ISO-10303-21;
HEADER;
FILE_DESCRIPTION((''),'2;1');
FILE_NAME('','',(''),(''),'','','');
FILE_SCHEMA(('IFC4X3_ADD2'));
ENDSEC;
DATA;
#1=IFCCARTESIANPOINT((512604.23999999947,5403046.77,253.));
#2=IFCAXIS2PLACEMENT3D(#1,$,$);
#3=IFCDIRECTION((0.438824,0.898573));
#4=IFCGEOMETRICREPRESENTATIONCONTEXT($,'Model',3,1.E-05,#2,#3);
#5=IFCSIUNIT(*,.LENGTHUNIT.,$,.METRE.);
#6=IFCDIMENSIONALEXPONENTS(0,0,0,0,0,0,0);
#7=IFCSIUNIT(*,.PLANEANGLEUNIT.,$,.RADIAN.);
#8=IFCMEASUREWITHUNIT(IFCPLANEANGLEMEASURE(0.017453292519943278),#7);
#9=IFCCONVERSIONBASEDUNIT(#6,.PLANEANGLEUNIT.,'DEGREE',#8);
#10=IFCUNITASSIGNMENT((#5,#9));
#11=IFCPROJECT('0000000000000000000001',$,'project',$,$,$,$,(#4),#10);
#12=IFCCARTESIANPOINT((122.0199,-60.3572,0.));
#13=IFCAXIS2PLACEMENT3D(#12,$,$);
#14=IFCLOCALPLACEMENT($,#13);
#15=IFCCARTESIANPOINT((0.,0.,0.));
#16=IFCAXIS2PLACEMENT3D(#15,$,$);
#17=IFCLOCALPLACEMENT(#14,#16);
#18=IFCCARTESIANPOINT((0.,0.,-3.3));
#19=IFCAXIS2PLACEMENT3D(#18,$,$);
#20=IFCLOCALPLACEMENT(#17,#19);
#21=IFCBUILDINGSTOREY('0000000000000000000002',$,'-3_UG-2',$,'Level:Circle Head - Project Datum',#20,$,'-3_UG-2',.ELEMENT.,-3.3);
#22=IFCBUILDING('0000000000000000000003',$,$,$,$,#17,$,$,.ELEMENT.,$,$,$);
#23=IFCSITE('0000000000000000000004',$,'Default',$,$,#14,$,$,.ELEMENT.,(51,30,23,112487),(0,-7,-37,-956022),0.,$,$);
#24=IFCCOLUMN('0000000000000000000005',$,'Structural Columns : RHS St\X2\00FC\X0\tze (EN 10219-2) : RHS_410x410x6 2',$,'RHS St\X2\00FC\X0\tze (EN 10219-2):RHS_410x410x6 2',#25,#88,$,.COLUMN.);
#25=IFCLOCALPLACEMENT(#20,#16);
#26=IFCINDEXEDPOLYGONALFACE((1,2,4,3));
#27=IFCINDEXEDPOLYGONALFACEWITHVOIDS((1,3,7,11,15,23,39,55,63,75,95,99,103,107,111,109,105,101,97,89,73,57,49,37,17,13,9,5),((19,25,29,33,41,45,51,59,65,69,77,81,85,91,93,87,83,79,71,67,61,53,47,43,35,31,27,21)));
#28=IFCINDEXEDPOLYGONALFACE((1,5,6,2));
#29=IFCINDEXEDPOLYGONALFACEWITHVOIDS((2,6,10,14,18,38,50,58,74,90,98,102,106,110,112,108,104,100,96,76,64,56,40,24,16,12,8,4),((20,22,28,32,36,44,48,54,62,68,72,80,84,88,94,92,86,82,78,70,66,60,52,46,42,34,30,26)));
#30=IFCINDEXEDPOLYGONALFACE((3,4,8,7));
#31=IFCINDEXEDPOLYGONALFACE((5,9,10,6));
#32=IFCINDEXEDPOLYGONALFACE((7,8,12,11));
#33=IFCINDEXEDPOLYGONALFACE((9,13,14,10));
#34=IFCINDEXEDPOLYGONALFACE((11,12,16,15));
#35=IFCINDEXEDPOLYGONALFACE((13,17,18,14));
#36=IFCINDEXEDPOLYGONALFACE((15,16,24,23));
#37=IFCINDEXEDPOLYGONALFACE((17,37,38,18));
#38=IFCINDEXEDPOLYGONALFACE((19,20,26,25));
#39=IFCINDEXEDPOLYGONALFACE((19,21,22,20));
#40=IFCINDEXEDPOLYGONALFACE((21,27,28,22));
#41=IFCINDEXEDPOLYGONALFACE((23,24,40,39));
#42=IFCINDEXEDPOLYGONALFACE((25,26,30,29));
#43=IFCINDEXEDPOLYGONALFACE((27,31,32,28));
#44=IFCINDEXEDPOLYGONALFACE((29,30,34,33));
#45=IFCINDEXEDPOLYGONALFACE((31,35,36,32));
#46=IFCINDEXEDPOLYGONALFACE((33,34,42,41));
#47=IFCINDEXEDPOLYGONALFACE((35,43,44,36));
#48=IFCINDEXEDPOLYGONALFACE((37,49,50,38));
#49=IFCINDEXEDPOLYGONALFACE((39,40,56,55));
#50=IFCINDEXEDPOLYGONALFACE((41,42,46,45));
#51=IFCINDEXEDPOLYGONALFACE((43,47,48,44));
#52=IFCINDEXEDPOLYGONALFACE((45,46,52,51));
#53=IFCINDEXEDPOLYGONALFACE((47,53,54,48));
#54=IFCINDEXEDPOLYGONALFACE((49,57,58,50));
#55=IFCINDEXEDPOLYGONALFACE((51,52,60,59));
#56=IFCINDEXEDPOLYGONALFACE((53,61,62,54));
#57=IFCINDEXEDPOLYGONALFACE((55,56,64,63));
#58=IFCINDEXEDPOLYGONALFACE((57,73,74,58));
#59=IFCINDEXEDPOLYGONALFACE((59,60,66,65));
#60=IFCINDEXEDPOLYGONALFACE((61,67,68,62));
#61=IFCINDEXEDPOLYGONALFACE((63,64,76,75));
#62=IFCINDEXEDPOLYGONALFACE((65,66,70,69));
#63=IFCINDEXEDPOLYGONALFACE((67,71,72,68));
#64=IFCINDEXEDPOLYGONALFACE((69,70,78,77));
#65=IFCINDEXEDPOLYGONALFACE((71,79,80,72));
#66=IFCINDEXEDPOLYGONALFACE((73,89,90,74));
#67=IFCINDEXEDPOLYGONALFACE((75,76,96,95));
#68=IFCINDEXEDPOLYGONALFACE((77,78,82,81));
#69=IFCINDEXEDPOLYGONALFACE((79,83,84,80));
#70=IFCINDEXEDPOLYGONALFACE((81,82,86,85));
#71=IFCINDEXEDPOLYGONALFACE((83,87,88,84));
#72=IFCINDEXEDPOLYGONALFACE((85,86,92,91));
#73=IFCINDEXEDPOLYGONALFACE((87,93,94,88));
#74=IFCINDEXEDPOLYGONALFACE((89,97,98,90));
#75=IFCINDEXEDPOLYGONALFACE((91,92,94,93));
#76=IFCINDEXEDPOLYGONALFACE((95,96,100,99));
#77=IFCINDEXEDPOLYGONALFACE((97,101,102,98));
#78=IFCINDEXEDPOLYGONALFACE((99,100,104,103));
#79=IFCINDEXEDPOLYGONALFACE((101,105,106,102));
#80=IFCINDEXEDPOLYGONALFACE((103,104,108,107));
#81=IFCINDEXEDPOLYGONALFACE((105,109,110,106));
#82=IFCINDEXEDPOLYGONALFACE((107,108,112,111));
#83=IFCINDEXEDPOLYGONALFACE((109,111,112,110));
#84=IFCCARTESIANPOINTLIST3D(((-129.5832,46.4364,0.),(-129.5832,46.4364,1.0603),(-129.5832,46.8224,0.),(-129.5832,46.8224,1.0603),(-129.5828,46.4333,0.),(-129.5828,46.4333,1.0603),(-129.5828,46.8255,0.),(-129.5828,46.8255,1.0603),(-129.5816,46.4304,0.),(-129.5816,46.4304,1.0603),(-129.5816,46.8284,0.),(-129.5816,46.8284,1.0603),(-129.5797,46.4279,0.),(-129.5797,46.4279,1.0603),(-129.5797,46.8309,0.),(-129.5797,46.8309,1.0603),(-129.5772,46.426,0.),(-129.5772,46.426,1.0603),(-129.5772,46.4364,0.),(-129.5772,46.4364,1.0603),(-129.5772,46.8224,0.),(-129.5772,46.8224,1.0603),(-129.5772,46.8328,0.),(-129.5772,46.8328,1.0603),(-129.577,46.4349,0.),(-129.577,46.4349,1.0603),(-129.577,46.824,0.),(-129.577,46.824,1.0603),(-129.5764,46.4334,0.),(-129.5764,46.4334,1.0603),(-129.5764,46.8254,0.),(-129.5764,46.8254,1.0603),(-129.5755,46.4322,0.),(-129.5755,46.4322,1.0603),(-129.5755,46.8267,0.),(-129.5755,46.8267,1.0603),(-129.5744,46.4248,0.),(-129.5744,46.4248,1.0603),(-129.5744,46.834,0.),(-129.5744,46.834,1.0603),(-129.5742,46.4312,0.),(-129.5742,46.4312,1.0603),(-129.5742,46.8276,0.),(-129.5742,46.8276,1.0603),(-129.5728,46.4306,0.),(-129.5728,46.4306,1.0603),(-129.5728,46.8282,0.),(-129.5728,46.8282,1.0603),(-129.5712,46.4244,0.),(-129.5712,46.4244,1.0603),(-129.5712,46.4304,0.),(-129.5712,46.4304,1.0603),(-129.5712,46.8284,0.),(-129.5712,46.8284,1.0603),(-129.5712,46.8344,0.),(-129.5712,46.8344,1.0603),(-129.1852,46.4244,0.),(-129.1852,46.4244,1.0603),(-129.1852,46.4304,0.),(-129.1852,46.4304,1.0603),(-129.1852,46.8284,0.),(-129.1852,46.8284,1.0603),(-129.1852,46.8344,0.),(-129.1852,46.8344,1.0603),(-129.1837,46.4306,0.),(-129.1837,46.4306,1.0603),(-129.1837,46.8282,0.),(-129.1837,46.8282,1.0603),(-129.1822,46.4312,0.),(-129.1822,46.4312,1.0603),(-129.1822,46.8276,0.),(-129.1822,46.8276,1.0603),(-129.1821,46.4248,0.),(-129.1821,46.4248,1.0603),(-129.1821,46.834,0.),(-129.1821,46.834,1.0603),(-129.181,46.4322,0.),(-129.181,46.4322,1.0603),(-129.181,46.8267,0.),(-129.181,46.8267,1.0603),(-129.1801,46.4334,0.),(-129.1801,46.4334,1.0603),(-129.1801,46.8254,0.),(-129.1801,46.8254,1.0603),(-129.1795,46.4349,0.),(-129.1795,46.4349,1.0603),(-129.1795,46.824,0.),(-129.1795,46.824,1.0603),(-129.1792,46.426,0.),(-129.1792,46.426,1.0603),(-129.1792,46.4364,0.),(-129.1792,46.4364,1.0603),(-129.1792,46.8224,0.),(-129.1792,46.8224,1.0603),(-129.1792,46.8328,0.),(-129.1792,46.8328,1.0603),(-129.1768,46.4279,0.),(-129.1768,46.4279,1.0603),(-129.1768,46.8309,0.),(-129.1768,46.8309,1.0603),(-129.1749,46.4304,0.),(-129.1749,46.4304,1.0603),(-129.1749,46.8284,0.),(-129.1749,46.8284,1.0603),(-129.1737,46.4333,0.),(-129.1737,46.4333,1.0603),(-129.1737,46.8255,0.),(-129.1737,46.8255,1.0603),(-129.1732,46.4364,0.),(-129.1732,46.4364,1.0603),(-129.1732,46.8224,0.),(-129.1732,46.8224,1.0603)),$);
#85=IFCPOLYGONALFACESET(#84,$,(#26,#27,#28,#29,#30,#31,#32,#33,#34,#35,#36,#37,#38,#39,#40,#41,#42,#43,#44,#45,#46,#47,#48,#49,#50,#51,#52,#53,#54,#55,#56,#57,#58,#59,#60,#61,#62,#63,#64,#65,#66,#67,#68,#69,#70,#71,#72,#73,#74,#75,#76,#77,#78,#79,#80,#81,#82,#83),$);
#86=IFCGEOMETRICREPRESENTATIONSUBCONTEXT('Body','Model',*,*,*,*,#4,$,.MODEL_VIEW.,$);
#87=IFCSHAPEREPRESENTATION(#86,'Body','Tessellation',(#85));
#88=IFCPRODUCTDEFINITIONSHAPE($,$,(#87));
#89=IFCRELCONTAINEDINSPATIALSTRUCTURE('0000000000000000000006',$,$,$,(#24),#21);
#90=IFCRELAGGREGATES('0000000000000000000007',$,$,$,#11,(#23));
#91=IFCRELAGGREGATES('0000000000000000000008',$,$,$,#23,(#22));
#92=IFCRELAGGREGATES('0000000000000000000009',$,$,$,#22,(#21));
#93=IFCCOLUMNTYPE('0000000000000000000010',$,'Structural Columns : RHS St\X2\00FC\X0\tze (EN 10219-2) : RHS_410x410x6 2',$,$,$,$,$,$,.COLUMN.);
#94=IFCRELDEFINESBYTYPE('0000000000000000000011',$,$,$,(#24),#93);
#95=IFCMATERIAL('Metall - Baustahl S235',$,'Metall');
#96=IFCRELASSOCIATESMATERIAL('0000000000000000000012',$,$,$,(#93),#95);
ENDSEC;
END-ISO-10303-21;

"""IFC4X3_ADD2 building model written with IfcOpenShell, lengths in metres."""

from ifc_helpers import new_model, entity, si_unit, converted_unit, direction, frame, frame_2d, origin, place, context, subcontext, project, spatial, polyline, circle_curve, parameter, trimmed, segment, composite_curve, outline, extrude, source, transform, mapped, material, material_profile, profile_set, type_object, type_shapes, element, save


model = new_model("IFC4X3_ADD2")

# Units and contexts
model_context = context("Model", 3, precision=1e-05, world=frame((512604.23999999947, 5403046.77, 253.0)), true_north=direction((0.438824, 0.898573)))
body_context = subcontext(model_context, "Body", "Model", "MODEL_VIEW")
ifc_project = project(units=[si_unit("LENGTHUNIT", "METRE"), converted_unit("PLANEANGLEUNIT", "DEGREE", entity("IfcPlaneAngleMeasure", 0.017453292519943278), si_unit("PLANEANGLEUNIT", "RADIAN"), dimensions=[0, 0, 0, 0, 0, 0, 0])], contexts=[model_context])

# Site, building, storey
site_placement = place(None, frame((122.0199, -60.3572, 0.0)))
site = spatial("IfcSite", under=ifc_project, at=site_placement, Name="Default", CompositionType="ELEMENT", RefLatitude=(51, 30, 23, 112487), RefLongitude=(0, -7, -37, -956022), RefElevation=0.0)
building_placement = place(site_placement, origin())
building = spatial("IfcBuilding", under=site, at=building_placement, CompositionType="ELEMENT")
storey_placement = place(building_placement, frame((0.0, 0.0, -3.3)))
storey = spatial("IfcBuildingStorey", under=building, at=storey_placement, Name="-3_UG-2", ObjectType="Level:Circle Head - Project Datum", LongName="-3_UG-2", CompositionType="ELEMENT", Elevation=-3.3)

# Column
ifc_material_1 = material(Name="Metall - Baustahl S235", Category="Metall")
ifc_material_profile_1 = material_profile(ifc_material_1, outline(composite_curve([segment(polyline([(-0.193, -0.205), (0.193, -0.205)]), True, "CONTINUOUS"), segment(trimmed(circle_curve(frame_2d((0.193, -0.193), x_axis=(-1.0, 0.0)), 0.012), [parameter(90.0)], [parameter(180.0)], True, "PARAMETER"), True, "CONTINUOUS"), segment(polyline([(0.205, -0.193), (0.205, 0.193)]), True, "CONTINUOUS"), segment(trimmed(circle_curve(frame_2d((0.193, 0.193), x_axis=(-1.0, 0.0)), 0.012), [parameter(180.0)], [parameter(270.0)], True, "PARAMETER"), True, "CONTINUOUS"), segment(polyline([(0.193, 0.205), (-0.193, 0.205)]), True, "CONTINUOUS"), segment(trimmed(circle_curve(frame_2d((-0.193, 0.193), x_axis=(-1.0, 0.0)), 0.012), [parameter(270.0)], [parameter(360.0)], True, "PARAMETER"), True, "CONTINUOUS"), segment(polyline([(-0.205, 0.193), (-0.205, -0.193)]), True, "CONTINUOUS"), segment(trimmed(circle_curve(frame_2d((-0.193, -0.193), x_axis=(-1.0, 0.0)), 0.012), [parameter(360.0)], [parameter(90.0)], True, "PARAMETER"), True, "CONTINUOUS")], self_intersect=False), holes=[composite_curve([segment(trimmed(circle_curve(frame_2d((-0.193, -0.193), x_axis=(-1.0, 0.0)), 0.006), [parameter(0.0)], [parameter(90.0)], True, "PARAMETER"), False, "CONTINUOUS"), segment(polyline([(-0.199, -0.193), (-0.199, 0.193)]), True, "CONTINUOUS"), segment(trimmed(circle_curve(frame_2d((-0.193, 0.193), x_axis=(-1.0, 0.0)), 0.006), [parameter(270.0)], [parameter(360.0)], True, "PARAMETER"), False, "CONTINUOUS"), segment(polyline([(-0.193, 0.199), (0.193, 0.199)]), True, "CONTINUOUS"), segment(trimmed(circle_curve(frame_2d((0.193, 0.193), x_axis=(-1.0, 0.0)), 0.006), [parameter(180.0)], [parameter(270.0)], True, "PARAMETER"), False, "CONTINUOUS"), segment(polyline([(0.199, 0.193), (0.199, -0.193)]), True, "CONTINUOUS"), segment(trimmed(circle_curve(frame_2d((0.193, -0.193), x_axis=(-1.0, 0.0)), 0.006), [parameter(90.0)], [parameter(180.0)], True, "PARAMETER"), False, "CONTINUOUS"), segment(polyline([(0.193, -0.199), (-0.193, -0.199)]), True, "CONTINUOUS")], self_intersect=False)]), Name="RHS_410x410x6 2")
ifc_profile_set_1 = profile_set([ifc_material_profile_1], Name="RHS_410x410x6 2")
column_type_1 = type_object("IfcColumnType", Name="Structural Columns : RHS Stütze (EN 10219-2) : RHS_410x410x6 2", PredefinedType="COLUMN", material=ifc_profile_set_1)
shared_shape_1 = source(origin(), body_context, "Body", "SweptSolid", [
    extrude(outline(composite_curve([segment(polyline([(-0.193, -0.205), (0.193, -0.205)]), True, "CONTINUOUS"), segment(trimmed(circle_curve(frame_2d((0.193, -0.193), x_axis=(-1.0, 0.0)), 0.012), [parameter(90.0)], [parameter(180.0)], True, "PARAMETER"), True, "CONTINUOUS"), segment(polyline([(0.205, -0.193), (0.205, 0.193)]), True, "CONTINUOUS"), segment(trimmed(circle_curve(frame_2d((0.193, 0.193), x_axis=(-1.0, 0.0)), 0.012), [parameter(180.0)], [parameter(270.0)], True, "PARAMETER"), True, "CONTINUOUS"), segment(polyline([(0.193, 0.205), (-0.193, 0.205)]), True, "CONTINUOUS"), segment(trimmed(circle_curve(frame_2d((-0.193, 0.193), x_axis=(-1.0, 0.0)), 0.012), [parameter(270.0)], [parameter(360.0)], True, "PARAMETER"), True, "CONTINUOUS"), segment(polyline([(-0.205, 0.193), (-0.205, -0.193)]), True, "CONTINUOUS"), segment(trimmed(circle_curve(frame_2d((-0.193, -0.193), x_axis=(-1.0, 0.0)), 0.012), [parameter(360.0)], [parameter(90.0)], True, "PARAMETER"), True, "CONTINUOUS")], self_intersect=False), holes=[composite_curve([segment(trimmed(circle_curve(frame_2d((-0.193, -0.193), x_axis=(-1.0, 0.0)), 0.006), [parameter(0.0)], [parameter(90.0)], True, "PARAMETER"), False, "CONTINUOUS"), segment(polyline([(-0.199, -0.193), (-0.199, 0.193)]), True, "CONTINUOUS"), segment(trimmed(circle_curve(frame_2d((-0.193, 0.193), x_axis=(-1.0, 0.0)), 0.006), [parameter(270.0)], [parameter(360.0)], True, "PARAMETER"), False, "CONTINUOUS"), segment(polyline([(-0.193, 0.199), (0.193, 0.199)]), True, "CONTINUOUS"), segment(trimmed(circle_curve(frame_2d((0.193, 0.193), x_axis=(-1.0, 0.0)), 0.006), [parameter(180.0)], [parameter(270.0)], True, "PARAMETER"), False, "CONTINUOUS"), segment(polyline([(0.199, 0.193), (0.199, -0.193)]), True, "CONTINUOUS"), segment(trimmed(circle_curve(frame_2d((0.193, -0.193), x_axis=(-1.0, 0.0)), 0.006), [parameter(90.0)], [parameter(180.0)], True, "PARAMETER"), False, "CONTINUOUS"), segment(polyline([(0.193, -0.199), (-0.193, -0.199)]), True, "CONTINUOUS")], self_intersect=False)]), frame((0.0, 0.0, -3.3), z_axis=(0.0, 0.0, 1.0), x_axis=(-1.0, 0.0, 0.0)), (0.0, 0.0, 1.0), 1.0603),
])
type_shapes(column_type_1, [shared_shape_1])
column_1_placement = place(storey_placement, frame((-129.3782, 46.6294, 3.3)))
element("IfcColumn", 1, at=column_1_placement, inside=storey, type_object=column_type_1, Name="Structural Columns : RHS Stütze (EN 10219-2) : RHS_410x410x6 2", ObjectType="RHS Stütze (EN 10219-2):RHS_410x410x6 2", PredefinedType="COLUMN", context=body_context, shape_type="MappedRepresentation", body=[
    mapped(shared_shape_1, transform((0.0, 0.0, 0.0), scale=1.0)),
])

save(model, "model.ifc")
